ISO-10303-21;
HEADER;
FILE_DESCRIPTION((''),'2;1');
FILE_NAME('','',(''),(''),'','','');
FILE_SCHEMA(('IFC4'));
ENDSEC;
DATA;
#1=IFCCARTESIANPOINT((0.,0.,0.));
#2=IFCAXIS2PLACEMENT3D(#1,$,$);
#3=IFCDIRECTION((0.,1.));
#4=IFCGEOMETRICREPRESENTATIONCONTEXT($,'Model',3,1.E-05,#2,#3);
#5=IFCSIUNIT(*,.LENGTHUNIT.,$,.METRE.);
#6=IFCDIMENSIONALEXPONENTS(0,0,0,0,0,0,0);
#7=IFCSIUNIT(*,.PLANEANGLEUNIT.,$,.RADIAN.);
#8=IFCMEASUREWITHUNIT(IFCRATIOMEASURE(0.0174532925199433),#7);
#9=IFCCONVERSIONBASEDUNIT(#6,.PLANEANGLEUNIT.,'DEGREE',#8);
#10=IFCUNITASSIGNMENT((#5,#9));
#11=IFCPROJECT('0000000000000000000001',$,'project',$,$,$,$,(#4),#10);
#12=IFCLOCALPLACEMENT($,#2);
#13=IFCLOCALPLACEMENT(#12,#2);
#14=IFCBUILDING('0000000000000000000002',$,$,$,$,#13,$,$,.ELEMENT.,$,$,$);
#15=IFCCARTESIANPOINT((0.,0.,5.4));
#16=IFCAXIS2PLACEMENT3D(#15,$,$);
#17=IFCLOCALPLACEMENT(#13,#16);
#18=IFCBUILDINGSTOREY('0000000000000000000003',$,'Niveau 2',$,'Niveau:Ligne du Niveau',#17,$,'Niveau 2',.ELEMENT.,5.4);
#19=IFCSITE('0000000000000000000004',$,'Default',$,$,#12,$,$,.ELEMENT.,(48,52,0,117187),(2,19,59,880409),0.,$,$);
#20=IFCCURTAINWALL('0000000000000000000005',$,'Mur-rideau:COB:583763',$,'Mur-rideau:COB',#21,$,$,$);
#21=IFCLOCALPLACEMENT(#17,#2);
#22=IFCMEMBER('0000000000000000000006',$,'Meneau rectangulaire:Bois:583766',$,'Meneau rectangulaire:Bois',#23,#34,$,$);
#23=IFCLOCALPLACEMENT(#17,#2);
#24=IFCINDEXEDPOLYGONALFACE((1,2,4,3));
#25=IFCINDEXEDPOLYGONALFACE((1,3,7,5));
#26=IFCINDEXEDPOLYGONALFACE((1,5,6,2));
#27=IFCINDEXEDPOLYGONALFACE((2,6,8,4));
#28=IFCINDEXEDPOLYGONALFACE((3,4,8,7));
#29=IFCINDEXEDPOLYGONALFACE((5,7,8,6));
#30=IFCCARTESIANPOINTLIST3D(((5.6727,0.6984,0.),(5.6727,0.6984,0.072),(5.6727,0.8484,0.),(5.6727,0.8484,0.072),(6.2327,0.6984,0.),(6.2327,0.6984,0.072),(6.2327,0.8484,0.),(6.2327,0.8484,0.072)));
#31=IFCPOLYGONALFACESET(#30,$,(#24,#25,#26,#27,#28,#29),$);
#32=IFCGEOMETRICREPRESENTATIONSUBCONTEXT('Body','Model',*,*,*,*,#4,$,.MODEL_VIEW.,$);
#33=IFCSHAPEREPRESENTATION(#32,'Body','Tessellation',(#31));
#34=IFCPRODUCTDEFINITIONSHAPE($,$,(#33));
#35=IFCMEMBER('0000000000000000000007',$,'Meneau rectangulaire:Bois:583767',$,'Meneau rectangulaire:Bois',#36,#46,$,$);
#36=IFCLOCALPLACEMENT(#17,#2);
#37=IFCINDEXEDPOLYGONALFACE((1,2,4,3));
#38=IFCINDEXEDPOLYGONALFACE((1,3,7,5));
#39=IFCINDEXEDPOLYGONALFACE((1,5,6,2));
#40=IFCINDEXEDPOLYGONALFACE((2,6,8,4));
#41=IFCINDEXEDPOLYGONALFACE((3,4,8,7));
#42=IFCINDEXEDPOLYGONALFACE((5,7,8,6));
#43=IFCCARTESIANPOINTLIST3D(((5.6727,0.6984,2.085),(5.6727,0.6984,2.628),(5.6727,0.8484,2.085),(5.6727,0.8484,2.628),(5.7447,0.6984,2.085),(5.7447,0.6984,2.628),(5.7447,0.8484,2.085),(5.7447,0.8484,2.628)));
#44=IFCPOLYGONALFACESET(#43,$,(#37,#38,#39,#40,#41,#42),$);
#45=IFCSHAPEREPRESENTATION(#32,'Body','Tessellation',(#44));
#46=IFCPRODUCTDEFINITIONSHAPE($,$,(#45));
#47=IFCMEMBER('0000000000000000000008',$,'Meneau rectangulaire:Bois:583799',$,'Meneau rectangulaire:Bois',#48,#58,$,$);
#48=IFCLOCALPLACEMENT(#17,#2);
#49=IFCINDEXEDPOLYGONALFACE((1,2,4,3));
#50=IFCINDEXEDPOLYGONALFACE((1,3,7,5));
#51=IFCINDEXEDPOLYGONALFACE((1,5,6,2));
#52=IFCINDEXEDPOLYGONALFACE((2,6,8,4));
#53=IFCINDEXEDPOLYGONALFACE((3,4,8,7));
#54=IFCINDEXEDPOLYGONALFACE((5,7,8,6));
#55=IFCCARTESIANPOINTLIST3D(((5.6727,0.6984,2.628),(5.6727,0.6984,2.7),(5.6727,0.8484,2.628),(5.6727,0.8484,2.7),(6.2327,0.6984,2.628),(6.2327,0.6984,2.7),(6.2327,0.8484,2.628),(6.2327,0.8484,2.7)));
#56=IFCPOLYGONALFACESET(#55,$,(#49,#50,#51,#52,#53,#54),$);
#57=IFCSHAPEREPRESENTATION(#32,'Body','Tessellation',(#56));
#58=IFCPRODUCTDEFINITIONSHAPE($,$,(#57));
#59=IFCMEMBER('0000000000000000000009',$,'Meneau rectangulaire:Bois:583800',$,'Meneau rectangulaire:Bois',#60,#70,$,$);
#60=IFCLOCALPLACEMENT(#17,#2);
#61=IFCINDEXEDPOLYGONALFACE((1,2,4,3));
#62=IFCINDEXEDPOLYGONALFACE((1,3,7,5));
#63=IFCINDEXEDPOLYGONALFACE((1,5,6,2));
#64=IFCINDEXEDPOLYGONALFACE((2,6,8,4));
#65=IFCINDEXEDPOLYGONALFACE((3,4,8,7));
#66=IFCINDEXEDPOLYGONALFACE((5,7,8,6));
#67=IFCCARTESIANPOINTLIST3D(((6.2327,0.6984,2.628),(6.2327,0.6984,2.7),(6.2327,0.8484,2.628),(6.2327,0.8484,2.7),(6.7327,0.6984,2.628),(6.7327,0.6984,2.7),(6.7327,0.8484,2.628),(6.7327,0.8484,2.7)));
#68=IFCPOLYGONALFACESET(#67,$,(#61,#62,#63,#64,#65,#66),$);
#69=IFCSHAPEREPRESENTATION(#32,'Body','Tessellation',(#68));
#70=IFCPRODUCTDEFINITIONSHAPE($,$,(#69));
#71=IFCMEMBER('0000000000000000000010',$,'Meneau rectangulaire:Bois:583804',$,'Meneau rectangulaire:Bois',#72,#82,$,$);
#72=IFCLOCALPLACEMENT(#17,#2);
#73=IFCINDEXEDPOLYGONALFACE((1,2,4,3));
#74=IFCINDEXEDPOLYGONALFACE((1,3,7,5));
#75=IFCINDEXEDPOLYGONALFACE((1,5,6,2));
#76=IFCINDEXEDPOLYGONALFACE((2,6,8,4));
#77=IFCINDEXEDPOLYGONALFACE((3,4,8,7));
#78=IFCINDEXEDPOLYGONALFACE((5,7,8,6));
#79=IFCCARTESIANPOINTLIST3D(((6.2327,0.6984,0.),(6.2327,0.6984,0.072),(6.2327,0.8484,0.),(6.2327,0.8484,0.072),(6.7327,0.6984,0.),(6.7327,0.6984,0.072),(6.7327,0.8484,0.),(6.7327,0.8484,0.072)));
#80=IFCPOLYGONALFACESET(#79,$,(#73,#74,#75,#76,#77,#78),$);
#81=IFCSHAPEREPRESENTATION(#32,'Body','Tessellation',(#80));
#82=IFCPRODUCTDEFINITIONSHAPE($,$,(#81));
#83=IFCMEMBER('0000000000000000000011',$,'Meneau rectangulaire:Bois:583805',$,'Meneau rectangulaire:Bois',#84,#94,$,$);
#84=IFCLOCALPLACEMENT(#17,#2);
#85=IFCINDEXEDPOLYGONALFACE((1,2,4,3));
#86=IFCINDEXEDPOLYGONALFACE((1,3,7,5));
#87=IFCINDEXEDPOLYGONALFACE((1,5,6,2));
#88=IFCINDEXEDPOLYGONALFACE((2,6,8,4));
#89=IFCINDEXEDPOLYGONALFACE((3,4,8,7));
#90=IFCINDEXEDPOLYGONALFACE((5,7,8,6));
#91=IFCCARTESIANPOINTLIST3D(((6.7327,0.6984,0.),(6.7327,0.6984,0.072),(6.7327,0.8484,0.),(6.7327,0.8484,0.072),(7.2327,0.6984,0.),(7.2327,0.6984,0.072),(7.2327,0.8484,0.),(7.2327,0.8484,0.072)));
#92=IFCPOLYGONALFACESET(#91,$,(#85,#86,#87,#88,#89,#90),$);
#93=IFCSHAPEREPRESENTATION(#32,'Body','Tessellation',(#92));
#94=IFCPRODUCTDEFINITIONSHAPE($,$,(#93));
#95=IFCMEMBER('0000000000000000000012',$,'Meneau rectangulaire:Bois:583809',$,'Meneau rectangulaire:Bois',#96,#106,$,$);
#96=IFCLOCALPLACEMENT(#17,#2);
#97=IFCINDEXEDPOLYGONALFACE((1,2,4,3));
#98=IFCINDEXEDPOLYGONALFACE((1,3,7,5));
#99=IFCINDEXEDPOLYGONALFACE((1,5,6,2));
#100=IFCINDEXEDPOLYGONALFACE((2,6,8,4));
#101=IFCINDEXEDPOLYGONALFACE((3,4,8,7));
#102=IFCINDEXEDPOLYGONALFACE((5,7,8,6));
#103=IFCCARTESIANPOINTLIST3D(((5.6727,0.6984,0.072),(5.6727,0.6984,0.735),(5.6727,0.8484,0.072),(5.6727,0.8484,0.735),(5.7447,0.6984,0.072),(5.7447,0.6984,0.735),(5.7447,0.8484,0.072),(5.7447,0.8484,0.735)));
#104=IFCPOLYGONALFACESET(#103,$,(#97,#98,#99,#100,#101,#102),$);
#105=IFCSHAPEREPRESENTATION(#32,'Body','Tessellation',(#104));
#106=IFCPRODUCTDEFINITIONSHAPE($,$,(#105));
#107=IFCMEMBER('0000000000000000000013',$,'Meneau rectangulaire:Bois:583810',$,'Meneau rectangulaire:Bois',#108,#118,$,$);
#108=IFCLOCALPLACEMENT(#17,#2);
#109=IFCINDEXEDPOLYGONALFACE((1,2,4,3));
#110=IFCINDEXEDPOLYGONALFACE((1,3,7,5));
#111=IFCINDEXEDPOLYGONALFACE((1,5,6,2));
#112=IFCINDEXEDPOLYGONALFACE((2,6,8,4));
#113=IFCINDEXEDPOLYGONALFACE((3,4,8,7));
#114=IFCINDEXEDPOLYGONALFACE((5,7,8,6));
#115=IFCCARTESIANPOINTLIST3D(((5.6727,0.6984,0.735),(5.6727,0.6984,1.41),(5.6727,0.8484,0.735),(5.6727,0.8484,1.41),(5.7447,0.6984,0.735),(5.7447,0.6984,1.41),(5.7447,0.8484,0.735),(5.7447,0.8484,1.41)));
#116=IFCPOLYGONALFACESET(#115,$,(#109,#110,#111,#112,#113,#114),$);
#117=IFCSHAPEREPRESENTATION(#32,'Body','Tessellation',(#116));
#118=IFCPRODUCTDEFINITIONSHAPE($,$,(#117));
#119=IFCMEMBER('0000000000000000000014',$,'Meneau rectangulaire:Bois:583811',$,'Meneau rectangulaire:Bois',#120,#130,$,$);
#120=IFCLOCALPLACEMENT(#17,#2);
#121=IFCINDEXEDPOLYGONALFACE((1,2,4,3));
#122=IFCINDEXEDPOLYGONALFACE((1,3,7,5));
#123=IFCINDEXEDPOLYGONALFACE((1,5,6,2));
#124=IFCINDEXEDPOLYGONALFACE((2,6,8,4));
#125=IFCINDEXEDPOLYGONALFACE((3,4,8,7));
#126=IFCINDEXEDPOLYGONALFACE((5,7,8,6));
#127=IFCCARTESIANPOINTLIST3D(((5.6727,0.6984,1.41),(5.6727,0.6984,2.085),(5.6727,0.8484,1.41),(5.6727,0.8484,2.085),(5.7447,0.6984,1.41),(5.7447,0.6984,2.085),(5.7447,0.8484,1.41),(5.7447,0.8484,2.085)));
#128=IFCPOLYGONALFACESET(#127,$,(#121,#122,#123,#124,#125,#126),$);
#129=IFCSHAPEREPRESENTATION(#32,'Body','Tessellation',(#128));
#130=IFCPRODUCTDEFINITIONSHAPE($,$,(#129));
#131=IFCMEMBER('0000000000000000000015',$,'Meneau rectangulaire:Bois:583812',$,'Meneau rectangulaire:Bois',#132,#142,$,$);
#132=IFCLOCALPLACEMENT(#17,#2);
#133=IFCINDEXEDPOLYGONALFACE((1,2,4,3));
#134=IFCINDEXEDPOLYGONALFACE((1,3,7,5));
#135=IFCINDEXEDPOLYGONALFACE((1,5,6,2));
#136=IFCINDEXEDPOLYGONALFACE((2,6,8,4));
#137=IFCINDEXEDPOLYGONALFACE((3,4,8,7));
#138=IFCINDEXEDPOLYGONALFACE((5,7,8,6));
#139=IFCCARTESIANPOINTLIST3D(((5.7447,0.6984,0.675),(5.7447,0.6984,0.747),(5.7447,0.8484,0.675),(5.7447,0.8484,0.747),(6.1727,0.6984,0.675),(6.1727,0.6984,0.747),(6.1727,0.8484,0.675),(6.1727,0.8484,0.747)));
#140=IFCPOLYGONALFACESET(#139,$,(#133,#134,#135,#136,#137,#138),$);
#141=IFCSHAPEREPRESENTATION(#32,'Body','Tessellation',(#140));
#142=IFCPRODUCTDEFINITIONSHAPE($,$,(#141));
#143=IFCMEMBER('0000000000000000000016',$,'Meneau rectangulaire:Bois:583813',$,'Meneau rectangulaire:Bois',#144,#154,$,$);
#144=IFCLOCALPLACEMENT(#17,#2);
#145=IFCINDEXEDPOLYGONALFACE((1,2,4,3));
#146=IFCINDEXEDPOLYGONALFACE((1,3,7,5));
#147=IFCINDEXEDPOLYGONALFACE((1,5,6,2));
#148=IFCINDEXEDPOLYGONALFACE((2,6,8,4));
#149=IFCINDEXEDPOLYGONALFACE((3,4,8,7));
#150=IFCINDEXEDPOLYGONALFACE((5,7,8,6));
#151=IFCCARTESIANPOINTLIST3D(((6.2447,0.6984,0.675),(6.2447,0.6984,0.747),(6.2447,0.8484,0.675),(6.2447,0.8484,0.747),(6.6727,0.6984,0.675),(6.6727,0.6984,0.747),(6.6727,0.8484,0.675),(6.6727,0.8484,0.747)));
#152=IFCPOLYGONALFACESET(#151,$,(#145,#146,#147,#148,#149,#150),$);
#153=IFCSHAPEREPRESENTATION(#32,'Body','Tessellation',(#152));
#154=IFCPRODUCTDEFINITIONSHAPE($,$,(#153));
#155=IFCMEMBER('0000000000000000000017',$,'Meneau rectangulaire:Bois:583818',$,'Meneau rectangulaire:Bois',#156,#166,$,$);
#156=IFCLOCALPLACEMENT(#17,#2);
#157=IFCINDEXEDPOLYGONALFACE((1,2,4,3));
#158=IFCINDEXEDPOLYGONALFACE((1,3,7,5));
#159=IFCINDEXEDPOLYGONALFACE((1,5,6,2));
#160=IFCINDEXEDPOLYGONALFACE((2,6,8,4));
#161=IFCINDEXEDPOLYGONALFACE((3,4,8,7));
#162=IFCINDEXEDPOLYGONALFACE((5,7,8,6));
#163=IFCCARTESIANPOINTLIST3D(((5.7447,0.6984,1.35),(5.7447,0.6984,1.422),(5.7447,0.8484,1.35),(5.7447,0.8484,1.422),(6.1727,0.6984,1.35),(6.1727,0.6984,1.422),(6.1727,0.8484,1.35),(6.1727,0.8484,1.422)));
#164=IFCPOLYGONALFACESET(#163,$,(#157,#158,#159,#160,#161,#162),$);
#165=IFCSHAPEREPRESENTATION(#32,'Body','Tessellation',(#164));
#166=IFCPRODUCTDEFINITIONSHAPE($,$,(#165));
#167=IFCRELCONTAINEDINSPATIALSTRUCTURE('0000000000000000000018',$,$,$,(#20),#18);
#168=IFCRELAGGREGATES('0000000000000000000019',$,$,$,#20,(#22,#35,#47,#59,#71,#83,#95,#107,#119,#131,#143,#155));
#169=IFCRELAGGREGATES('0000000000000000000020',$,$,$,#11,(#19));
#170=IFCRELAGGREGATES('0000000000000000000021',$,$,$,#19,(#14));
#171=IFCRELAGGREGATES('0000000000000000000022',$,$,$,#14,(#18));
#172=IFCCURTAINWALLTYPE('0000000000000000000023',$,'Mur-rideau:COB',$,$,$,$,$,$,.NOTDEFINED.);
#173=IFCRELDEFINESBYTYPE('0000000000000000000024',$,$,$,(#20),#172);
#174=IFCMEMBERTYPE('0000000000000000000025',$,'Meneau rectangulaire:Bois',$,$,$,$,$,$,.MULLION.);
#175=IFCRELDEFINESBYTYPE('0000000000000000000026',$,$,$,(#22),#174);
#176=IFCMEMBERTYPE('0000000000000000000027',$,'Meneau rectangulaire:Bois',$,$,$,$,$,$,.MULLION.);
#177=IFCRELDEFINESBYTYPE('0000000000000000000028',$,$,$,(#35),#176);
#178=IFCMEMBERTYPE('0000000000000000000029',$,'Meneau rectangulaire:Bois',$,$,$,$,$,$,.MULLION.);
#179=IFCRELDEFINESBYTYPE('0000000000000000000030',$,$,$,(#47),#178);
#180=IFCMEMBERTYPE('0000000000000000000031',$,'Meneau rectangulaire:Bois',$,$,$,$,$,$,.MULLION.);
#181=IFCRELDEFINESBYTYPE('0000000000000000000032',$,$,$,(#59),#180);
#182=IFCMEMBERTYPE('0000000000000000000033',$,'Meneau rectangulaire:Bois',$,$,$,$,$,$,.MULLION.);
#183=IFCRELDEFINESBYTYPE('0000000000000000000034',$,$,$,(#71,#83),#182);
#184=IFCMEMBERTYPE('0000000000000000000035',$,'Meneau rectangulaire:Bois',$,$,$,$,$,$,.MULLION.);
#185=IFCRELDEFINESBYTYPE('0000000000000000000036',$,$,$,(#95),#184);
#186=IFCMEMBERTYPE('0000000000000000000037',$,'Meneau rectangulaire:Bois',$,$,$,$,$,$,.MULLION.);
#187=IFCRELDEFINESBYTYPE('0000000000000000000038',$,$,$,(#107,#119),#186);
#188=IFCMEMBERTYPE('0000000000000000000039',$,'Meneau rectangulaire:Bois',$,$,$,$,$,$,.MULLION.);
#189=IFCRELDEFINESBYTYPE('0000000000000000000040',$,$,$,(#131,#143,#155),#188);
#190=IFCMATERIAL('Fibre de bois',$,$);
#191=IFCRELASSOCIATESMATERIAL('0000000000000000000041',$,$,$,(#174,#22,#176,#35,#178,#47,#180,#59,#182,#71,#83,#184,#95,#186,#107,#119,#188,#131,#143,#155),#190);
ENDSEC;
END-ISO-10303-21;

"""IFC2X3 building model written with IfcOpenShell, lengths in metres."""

from ifc_helpers import new_model, entity, si_unit, converted_unit, direction, frame, origin, origin_2d_with_axis, place, context, subcontext, project, spatial, rectangle, extrude, source, transform, mapped, material, type_object, type_shapes, element, aggregate, save


model = new_model("IFC2X3")

# Units and contexts
model_context = context("Model", 3, precision=1e-05, world=origin(), true_north=direction((0.0, 1.0)))
body_context = subcontext(model_context, "Body", "Model", "MODEL_VIEW")
ifc_project = project(units=[si_unit("LENGTHUNIT", "METRE"), converted_unit("PLANEANGLEUNIT", "DEGREE", entity("IfcRatioMeasure", 0.0174532925199433), si_unit("PLANEANGLEUNIT", "RADIAN"), dimensions=[0, 0, 0, 0, 0, 0, 0])], contexts=[model_context])

# Site, building, storey
site_placement = place(None, origin())
site = spatial("IfcSite", under=ifc_project, at=site_placement, Name="Default", CompositionType="ELEMENT", RefLatitude=(48, 52, 0, 117187), RefLongitude=(2, 19, 59, 880409), RefElevation=0.0)
building_placement = place(site_placement, origin())
building = spatial("IfcBuilding", under=site, at=building_placement, CompositionType="ELEMENT")
storey_placement = place(building_placement, frame((0.0, 0.0, 5.4)))
storey = spatial("IfcBuildingStorey", under=building, at=storey_placement, Name="Niveau 2", ObjectType="Niveau:Ligne du Niveau", LongName="Niveau 2", CompositionType="ELEMENT", Elevation=5.4)

# Curtain wall, members
curtain_wall_type_1 = type_object("IfcCurtainWallType", Name="Mur-rideau:COB", PredefinedType="NOTDEFINED")
curtain_wall_1_placement = place(storey_placement, frame((0.0, 0.0, -5.4)))
curtain_wall_1 = element("IfcCurtainWall", 1, at=curtain_wall_1_placement, inside=storey, type_object=curtain_wall_type_1, Name="Mur-rideau:COB:583763", ObjectType="Mur-rideau:COB")
ifc_material_1 = material(Name="Fibre de bois")
member_type_1 = type_object("IfcMemberType", Name="Meneau rectangulaire:Bois", PredefinedType="MULLION", material=ifc_material_1)
shared_shape_1 = source(origin(), body_context, "Body", "SweptSolid", [
    extrude(rectangle(XDim=0.15, YDim=0.072, at=origin_2d_with_axis()), frame((-0.036, 0.0, -0.56), z_axis=(0.0, 0.0, 1.0), x_axis=(0.0, -1.0, 0.0)), (0.0, 0.0, 1.0), 0.56),
])
type_shapes(member_type_1, [shared_shape_1])
member_1_placement = place(storey_placement, frame((5.6727, 0.7734, 0.0), z_axis=(-1.0, 0.0, 0.0), x_axis=(0.0, 0.0, -1.0)))
member_1 = element("IfcMember", 2, at=member_1_placement, type_object=member_type_1, material=ifc_material_1, Name="Meneau rectangulaire:Bois:583766", ObjectType="Meneau rectangulaire:Bois", context=body_context, shape_type="MappedRepresentation", body=[
    mapped(shared_shape_1, transform((0.0, 0.0, 0.0), scale=1.0)),
])
member_type_2 = type_object("IfcMemberType", Name="Meneau rectangulaire:Bois", PredefinedType="MULLION", material=ifc_material_1)
shared_shape_2 = source(origin(), body_context, "Body", "SweptSolid", [
    extrude(rectangle(XDim=0.15, YDim=0.072, at=origin_2d_with_axis()), frame((-0.036, 0.0, -0.543), z_axis=(0.0, 0.0, 1.0), x_axis=(0.0, -1.0, 0.0)), (0.0, 0.0, 1.0), 0.543),
])
type_shapes(member_type_2, [shared_shape_2])
member_2_placement = place(storey_placement, frame((5.6727, 0.7734, 2.628), z_axis=(0.0, 0.0, 1.0), x_axis=(-1.0, 0.0, 0.0)))
member_2 = element("IfcMember", 3, at=member_2_placement, type_object=member_type_2, material=ifc_material_1, Name="Meneau rectangulaire:Bois:583767", ObjectType="Meneau rectangulaire:Bois", context=body_context, shape_type="MappedRepresentation", body=[
    mapped(shared_shape_2, transform((0.0, 0.0, 0.0), scale=1.0)),
])
member_type_3 = type_object("IfcMemberType", Name="Meneau rectangulaire:Bois", PredefinedType="MULLION", material=ifc_material_1)
shared_shape_3 = source(origin(), body_context, "Body", "SweptSolid", [
    extrude(rectangle(XDim=0.15, YDim=0.072, at=origin_2d_with_axis()), frame((-0.036, 0.0, -0.56), z_axis=(0.0, 0.0, 1.0), x_axis=(0.0, -1.0, 0.0)), (0.0, 0.0, 1.0), 0.56),
])
type_shapes(member_type_3, [shared_shape_3])
member_3_placement = place(storey_placement, frame((6.2327, 0.7734, 2.7), z_axis=(1.0, 0.0, 0.0), x_axis=(0.0, 0.0, 1.0)))
member_3 = element("IfcMember", 4, at=member_3_placement, type_object=member_type_3, material=ifc_material_1, Name="Meneau rectangulaire:Bois:583799", ObjectType="Meneau rectangulaire:Bois", context=body_context, shape_type="MappedRepresentation", body=[
    mapped(shared_shape_3, transform((0.0, 0.0, 0.0), scale=1.0)),
])
member_type_4 = type_object("IfcMemberType", Name="Meneau rectangulaire:Bois", PredefinedType="MULLION", material=ifc_material_1)
shared_shape_4 = source(origin(), body_context, "Body", "SweptSolid", [
    extrude(rectangle(XDim=0.15, YDim=0.072, at=origin_2d_with_axis()), frame((-0.036, 0.0, -0.5), z_axis=(0.0, 0.0, 1.0), x_axis=(0.0, -1.0, 0.0)), (0.0, 0.0, 1.0), 0.5),
])
type_shapes(member_type_4, [shared_shape_4])
member_4_placement = place(storey_placement, frame((6.7327, 0.7734, 2.7), z_axis=(1.0, 0.0, 0.0), x_axis=(0.0, 0.0, 1.0)))
member_4 = element("IfcMember", 5, at=member_4_placement, type_object=member_type_4, material=ifc_material_1, Name="Meneau rectangulaire:Bois:583800", ObjectType="Meneau rectangulaire:Bois", context=body_context, shape_type="MappedRepresentation", body=[
    mapped(shared_shape_4, transform((0.0, 0.0, 0.0), scale=1.0)),
])
member_type_5 = type_object("IfcMemberType", Name="Meneau rectangulaire:Bois", PredefinedType="MULLION", material=ifc_material_1)
shared_shape_5 = source(origin(), body_context, "Body", "SweptSolid", [
    extrude(rectangle(XDim=0.15, YDim=0.072, at=origin_2d_with_axis()), frame((-0.036, 0.0, -0.5), z_axis=(0.0, 0.0, 1.0), x_axis=(0.0, -1.0, 0.0)), (0.0, 0.0, 1.0), 0.5),
])
type_shapes(member_type_5, [shared_shape_5])
member_5_placement = place(storey_placement, frame((6.2327, 0.7734, 0.0), z_axis=(-1.0, 0.0, 0.0), x_axis=(0.0, 0.0, -1.0)))
member_5 = element("IfcMember", 6, at=member_5_placement, type_object=member_type_5, material=ifc_material_1, Name="Meneau rectangulaire:Bois:583804", ObjectType="Meneau rectangulaire:Bois", context=body_context, shape_type="MappedRepresentation", body=[
    mapped(shared_shape_5, transform((0.0, 0.0, 0.0), scale=1.0)),
])
member_6_placement = place(storey_placement, frame((6.7327, 0.7734, 0.0), z_axis=(-1.0, 0.0, 0.0), x_axis=(0.0, 0.0, -1.0)))
member_6 = element("IfcMember", 7, at=member_6_placement, type_object=member_type_5, material=ifc_material_1, Name="Meneau rectangulaire:Bois:583805", ObjectType="Meneau rectangulaire:Bois", context=body_context, shape_type="MappedRepresentation", body=[
    mapped(shared_shape_5, transform((0.0, 0.0, 0.0), scale=1.0)),
])
member_type_6 = type_object("IfcMemberType", Name="Meneau rectangulaire:Bois", PredefinedType="MULLION", material=ifc_material_1)
shared_shape_6 = source(origin(), body_context, "Body", "SweptSolid", [
    extrude(rectangle(XDim=0.15, YDim=0.072, at=origin_2d_with_axis()), frame((-0.036, 0.0, -0.663), z_axis=(0.0, 0.0, 1.0), x_axis=(0.0, -1.0, 0.0)), (0.0, 0.0, 1.0), 0.663),
])
type_shapes(member_type_6, [shared_shape_6])
member_7_placement = place(storey_placement, frame((5.6727, 0.7734, 0.735), z_axis=(0.0, 0.0, 1.0), x_axis=(-1.0, 0.0, 0.0)))
member_7 = element("IfcMember", 8, at=member_7_placement, type_object=member_type_6, material=ifc_material_1, Name="Meneau rectangulaire:Bois:583809", ObjectType="Meneau rectangulaire:Bois", context=body_context, shape_type="MappedRepresentation", body=[
    mapped(shared_shape_6, transform((0.0, 0.0, 0.0), scale=1.0)),
])
member_type_7 = type_object("IfcMemberType", Name="Meneau rectangulaire:Bois", PredefinedType="MULLION", material=ifc_material_1)
shared_shape_7 = source(origin(), body_context, "Body", "SweptSolid", [
    extrude(rectangle(XDim=0.15, YDim=0.072, at=origin_2d_with_axis()), frame((-0.036, 0.0, -0.675), z_axis=(0.0, 0.0, 1.0), x_axis=(0.0, -1.0, 0.0)), (0.0, 0.0, 1.0), 0.675),
])
type_shapes(member_type_7, [shared_shape_7])
member_8_placement = place(storey_placement, frame((5.6727, 0.7734, 1.41), z_axis=(0.0, 0.0, 1.0), x_axis=(-1.0, 0.0, 0.0)))
member_8 = element("IfcMember", 9, at=member_8_placement, type_object=member_type_7, material=ifc_material_1, Name="Meneau rectangulaire:Bois:583810", ObjectType="Meneau rectangulaire:Bois", context=body_context, shape_type="MappedRepresentation", body=[
    mapped(shared_shape_7, transform((0.0, 0.0, 0.0), scale=1.0)),
])
member_9_placement = place(storey_placement, frame((5.6727, 0.7734, 2.085), z_axis=(0.0, 0.0, 1.0), x_axis=(-1.0, 0.0, 0.0)))
member_9 = element("IfcMember", 10, at=member_9_placement, type_object=member_type_7, material=ifc_material_1, Name="Meneau rectangulaire:Bois:583811", ObjectType="Meneau rectangulaire:Bois", context=body_context, shape_type="MappedRepresentation", body=[
    mapped(shared_shape_7, transform((0.0, 0.0, 0.0), scale=1.0)),
])
member_type_8 = type_object("IfcMemberType", Name="Meneau rectangulaire:Bois", PredefinedType="MULLION", material=ifc_material_1)
shared_shape_8 = source(origin(), body_context, "Body", "SweptSolid", [
    extrude(rectangle(XDim=0.15, YDim=0.072, at=origin_2d_with_axis()), frame((-0.024, 0.0, -0.428), z_axis=(0.0, 0.0, 1.0), x_axis=(0.0, -1.0, 0.0)), (0.0, 0.0, 1.0), 0.428),
])
type_shapes(member_type_8, [shared_shape_8])
member_10_placement = place(storey_placement, frame((6.1727, 0.7734, 0.735), z_axis=(1.0, 0.0, 0.0), x_axis=(0.0, 0.0, 1.0)))
member_10 = element("IfcMember", 11, at=member_10_placement, type_object=member_type_8, material=ifc_material_1, Name="Meneau rectangulaire:Bois:583812", ObjectType="Meneau rectangulaire:Bois", context=body_context, shape_type="MappedRepresentation", body=[
    mapped(shared_shape_8, transform((0.0, 0.0, 0.0), scale=1.0)),
])
member_11_placement = place(storey_placement, frame((6.6727, 0.7734, 0.735), z_axis=(1.0, 0.0, 0.0), x_axis=(0.0, 0.0, 1.0)))
member_11 = element("IfcMember", 12, at=member_11_placement, type_object=member_type_8, material=ifc_material_1, Name="Meneau rectangulaire:Bois:583813", ObjectType="Meneau rectangulaire:Bois", context=body_context, shape_type="MappedRepresentation", body=[
    mapped(shared_shape_8, transform((0.0, 0.0, 0.0), scale=1.0)),
])
member_12_placement = place(storey_placement, frame((6.1727, 0.7734, 1.41), z_axis=(1.0, 0.0, 0.0), x_axis=(0.0, 0.0, 1.0)))
member_12 = element("IfcMember", 13, at=member_12_placement, type_object=member_type_8, material=ifc_material_1, Name="Meneau rectangulaire:Bois:583818", ObjectType="Meneau rectangulaire:Bois", context=body_context, shape_type="MappedRepresentation", body=[
    mapped(shared_shape_8, transform((0.0, 0.0, 0.0), scale=1.0)),
])
aggregate(curtain_wall_1, [member_1, member_2, member_3, member_4, member_5, member_6, member_7, member_8, member_9, member_10, member_11, member_12])

save(model, "model.ifc")
